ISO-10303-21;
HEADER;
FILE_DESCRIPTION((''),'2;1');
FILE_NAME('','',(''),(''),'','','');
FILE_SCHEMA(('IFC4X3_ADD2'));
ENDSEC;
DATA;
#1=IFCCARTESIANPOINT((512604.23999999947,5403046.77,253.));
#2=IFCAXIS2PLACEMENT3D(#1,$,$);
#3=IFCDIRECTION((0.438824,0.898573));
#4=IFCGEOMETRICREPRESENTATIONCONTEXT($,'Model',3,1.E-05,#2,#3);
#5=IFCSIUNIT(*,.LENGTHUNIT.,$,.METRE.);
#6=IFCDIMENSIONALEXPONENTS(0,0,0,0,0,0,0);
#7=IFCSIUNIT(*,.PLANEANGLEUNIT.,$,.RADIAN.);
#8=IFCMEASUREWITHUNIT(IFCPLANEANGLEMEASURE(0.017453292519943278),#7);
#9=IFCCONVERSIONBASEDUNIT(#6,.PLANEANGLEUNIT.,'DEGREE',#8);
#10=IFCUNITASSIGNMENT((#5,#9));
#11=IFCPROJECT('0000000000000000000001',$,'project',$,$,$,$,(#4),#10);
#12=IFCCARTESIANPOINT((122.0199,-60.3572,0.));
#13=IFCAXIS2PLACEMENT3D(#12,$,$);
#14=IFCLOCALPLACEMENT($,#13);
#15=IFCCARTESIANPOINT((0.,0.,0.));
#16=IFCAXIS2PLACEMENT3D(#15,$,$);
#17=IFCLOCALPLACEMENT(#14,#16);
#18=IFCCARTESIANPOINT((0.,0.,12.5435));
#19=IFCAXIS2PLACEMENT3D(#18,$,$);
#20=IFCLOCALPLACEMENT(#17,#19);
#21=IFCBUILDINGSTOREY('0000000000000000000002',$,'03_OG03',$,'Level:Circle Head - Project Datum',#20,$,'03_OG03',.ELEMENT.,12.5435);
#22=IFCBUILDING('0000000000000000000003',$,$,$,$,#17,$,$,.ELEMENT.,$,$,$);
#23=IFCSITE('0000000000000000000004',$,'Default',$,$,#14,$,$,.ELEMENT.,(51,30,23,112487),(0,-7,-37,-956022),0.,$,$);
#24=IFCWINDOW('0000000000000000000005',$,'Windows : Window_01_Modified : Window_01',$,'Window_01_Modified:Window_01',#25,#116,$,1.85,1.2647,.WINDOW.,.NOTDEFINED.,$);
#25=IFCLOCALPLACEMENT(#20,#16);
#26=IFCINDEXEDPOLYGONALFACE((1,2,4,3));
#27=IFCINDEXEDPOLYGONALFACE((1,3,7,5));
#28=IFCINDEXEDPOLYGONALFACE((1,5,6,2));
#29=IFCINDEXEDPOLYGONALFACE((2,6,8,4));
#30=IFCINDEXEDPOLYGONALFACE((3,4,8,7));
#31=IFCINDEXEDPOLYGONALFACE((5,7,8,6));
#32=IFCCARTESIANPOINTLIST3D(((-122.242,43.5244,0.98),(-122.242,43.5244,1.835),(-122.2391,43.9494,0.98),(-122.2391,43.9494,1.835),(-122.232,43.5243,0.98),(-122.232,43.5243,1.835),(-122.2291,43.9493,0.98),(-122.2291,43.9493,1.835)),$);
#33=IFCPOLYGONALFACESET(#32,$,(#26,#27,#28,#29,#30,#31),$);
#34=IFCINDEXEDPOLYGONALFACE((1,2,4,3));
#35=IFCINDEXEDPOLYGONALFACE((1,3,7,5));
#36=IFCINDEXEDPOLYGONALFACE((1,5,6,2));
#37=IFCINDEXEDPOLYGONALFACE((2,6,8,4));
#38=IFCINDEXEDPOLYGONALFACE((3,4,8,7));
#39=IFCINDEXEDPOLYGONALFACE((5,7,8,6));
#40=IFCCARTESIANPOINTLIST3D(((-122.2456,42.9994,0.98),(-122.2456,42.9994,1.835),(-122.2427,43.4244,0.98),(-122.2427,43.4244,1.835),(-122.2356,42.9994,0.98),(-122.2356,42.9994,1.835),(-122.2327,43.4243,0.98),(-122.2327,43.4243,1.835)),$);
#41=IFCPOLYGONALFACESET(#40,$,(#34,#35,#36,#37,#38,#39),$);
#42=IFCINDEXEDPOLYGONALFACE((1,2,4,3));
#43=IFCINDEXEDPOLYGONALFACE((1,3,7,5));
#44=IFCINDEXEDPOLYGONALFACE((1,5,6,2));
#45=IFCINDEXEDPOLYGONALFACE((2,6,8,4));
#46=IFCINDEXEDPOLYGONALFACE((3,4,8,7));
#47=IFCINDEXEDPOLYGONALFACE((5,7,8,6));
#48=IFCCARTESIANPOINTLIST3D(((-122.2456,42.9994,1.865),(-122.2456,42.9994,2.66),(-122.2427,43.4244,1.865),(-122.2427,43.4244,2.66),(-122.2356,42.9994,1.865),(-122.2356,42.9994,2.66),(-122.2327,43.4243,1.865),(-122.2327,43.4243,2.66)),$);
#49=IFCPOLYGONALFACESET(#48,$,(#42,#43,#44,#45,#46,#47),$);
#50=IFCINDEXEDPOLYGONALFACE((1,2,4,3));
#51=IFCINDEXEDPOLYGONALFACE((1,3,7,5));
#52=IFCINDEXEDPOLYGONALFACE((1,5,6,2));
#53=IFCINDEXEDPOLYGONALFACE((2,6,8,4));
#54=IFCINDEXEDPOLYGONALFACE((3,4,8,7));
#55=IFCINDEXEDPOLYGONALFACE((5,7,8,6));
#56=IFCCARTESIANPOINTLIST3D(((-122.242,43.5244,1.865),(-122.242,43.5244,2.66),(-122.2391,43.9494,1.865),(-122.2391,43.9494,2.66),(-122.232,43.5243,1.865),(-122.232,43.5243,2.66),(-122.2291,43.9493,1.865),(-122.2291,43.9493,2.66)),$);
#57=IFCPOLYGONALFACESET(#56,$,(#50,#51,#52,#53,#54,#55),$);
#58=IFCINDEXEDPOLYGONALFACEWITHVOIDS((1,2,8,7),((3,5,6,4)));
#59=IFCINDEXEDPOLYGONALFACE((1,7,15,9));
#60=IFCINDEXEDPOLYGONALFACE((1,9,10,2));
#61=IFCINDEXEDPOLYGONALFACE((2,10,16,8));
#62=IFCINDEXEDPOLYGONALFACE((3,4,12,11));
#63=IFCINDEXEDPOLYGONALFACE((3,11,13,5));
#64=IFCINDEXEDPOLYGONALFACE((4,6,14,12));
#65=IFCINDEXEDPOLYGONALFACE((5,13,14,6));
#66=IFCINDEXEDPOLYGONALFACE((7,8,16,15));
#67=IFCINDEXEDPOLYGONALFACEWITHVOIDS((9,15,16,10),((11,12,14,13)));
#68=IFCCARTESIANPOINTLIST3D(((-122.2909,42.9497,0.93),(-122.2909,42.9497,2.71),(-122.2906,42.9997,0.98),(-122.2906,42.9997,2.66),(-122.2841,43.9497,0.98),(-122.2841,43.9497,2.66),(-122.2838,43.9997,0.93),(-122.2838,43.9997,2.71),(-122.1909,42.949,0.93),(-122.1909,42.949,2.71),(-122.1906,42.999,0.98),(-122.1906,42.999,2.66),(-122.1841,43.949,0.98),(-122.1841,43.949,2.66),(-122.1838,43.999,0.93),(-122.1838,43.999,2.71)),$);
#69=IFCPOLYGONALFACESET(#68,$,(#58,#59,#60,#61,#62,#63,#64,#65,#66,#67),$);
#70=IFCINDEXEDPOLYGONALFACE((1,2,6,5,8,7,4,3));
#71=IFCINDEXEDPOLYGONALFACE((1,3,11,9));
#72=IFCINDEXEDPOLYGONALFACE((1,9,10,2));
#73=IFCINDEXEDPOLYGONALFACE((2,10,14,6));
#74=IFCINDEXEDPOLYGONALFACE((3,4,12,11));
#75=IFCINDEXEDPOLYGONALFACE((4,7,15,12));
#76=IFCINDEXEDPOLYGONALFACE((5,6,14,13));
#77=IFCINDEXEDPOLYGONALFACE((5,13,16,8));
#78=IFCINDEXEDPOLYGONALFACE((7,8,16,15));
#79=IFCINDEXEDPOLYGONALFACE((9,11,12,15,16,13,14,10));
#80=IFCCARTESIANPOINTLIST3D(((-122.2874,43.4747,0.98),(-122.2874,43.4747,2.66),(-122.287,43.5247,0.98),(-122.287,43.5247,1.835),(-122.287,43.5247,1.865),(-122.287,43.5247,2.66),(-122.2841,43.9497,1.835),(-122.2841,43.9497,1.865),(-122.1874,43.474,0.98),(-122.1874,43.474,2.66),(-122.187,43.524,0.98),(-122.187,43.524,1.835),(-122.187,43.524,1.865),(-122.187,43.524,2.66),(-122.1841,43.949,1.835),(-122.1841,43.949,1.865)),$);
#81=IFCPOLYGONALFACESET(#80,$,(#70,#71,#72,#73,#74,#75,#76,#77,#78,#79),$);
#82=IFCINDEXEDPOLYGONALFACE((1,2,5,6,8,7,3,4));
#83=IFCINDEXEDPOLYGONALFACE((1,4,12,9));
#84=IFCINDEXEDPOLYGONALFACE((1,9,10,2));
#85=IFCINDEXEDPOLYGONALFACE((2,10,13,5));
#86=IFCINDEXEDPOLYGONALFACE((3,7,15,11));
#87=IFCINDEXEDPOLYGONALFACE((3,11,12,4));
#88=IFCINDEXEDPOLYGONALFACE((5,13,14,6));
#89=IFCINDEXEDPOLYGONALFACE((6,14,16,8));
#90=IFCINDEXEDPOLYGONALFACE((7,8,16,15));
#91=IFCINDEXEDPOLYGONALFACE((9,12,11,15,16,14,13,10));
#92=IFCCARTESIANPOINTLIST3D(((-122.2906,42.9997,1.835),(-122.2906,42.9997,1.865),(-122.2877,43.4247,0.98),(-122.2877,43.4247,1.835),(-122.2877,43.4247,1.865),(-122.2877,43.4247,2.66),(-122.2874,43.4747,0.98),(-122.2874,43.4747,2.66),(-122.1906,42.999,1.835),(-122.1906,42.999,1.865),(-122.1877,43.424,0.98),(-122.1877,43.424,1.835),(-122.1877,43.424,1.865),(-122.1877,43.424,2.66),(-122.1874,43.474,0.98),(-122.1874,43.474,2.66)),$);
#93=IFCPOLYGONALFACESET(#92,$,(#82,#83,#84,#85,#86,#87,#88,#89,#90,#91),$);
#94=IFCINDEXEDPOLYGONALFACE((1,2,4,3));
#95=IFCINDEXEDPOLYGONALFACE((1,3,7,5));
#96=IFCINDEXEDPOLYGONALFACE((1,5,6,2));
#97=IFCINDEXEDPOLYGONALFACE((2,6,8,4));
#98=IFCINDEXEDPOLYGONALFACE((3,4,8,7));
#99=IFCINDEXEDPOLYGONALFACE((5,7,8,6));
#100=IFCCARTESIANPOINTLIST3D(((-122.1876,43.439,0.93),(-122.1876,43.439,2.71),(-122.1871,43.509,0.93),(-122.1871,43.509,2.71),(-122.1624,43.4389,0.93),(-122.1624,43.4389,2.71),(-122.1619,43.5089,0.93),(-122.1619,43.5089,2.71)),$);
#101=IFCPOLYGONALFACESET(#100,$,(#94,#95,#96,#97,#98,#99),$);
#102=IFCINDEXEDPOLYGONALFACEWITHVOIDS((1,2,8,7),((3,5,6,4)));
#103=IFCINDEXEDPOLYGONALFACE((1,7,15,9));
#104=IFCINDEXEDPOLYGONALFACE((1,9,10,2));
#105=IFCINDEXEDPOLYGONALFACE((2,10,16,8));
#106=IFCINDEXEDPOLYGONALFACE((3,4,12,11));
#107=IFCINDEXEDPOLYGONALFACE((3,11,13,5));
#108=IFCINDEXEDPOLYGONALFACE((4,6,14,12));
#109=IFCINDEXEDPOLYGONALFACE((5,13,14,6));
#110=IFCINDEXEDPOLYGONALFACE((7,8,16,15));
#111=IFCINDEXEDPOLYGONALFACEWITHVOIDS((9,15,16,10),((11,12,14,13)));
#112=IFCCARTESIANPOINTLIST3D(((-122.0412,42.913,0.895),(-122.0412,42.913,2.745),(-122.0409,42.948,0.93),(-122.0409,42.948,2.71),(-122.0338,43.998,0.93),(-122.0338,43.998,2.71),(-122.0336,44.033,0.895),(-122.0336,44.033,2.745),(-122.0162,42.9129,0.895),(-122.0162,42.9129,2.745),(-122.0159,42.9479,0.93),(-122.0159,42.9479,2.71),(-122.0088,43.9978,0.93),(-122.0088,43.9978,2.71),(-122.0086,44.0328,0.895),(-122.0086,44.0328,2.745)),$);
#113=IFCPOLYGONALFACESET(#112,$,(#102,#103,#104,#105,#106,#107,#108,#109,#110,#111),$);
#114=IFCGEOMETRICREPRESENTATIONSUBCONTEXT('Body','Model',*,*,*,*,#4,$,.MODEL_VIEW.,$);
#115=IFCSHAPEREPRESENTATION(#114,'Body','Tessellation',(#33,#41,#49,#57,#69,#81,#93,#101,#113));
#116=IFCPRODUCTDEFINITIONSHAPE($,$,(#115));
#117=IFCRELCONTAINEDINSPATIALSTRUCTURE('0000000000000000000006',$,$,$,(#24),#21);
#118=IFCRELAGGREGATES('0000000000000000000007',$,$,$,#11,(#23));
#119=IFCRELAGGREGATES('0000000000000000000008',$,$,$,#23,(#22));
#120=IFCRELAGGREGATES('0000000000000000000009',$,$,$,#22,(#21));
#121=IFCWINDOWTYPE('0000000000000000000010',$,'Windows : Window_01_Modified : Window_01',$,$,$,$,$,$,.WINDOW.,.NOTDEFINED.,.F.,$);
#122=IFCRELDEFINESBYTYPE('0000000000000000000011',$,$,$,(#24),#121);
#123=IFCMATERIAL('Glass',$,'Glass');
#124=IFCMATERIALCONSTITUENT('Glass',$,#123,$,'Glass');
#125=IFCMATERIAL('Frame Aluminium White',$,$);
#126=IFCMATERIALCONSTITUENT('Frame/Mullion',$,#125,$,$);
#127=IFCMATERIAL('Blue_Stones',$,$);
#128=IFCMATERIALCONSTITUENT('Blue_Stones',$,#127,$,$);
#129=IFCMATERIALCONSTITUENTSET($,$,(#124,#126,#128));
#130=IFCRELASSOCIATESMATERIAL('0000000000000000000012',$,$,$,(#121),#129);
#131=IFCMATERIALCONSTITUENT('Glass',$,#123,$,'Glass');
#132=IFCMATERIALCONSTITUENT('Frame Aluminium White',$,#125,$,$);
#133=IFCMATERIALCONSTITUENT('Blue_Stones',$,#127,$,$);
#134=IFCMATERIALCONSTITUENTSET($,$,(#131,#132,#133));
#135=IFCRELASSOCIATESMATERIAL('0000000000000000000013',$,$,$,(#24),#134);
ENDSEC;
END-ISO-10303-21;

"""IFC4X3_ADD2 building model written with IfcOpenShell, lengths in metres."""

from ifc_helpers import new_model, entity, si_unit, converted_unit, direction, frame, frame_2d, origin, place, context, subcontext, project, spatial, polyline, rectangle, outline, extrude, source, transform, mapped, material, constituent, constituent_set, type_object, type_shapes, element, save


model = new_model("IFC4X3_ADD2")

# Units and contexts
model_context = context("Model", 3, precision=1e-05, world=frame((512604.23999999947, 5403046.77, 253.0)), true_north=direction((0.438824, 0.898573)))
body_context = subcontext(model_context, "Body", "Model", "MODEL_VIEW")
ifc_project = project(units=[si_unit("LENGTHUNIT", "METRE"), converted_unit("PLANEANGLEUNIT", "DEGREE", entity("IfcPlaneAngleMeasure", 0.017453292519943278), si_unit("PLANEANGLEUNIT", "RADIAN"), dimensions=[0, 0, 0, 0, 0, 0, 0])], contexts=[model_context])

# Site, building, storey
site_placement = place(None, frame((122.0199, -60.3572, 0.0)))
site = spatial("IfcSite", under=ifc_project, at=site_placement, Name="Default", CompositionType="ELEMENT", RefLatitude=(51, 30, 23, 112487), RefLongitude=(0, -7, -37, -956022), RefElevation=0.0)
building_placement = place(site_placement, origin())
building = spatial("IfcBuilding", under=site, at=building_placement, CompositionType="ELEMENT")
storey_placement = place(building_placement, frame((0.0, 0.0, 12.5435)))
storey = spatial("IfcBuildingStorey", under=building, at=storey_placement, Name="03_OG03", ObjectType="Level:Circle Head - Project Datum", LongName="03_OG03", CompositionType="ELEMENT", Elevation=12.5435)

# Window
ifc_material_1 = material(Name="Glass", Category="Glass")
ifc_material_2 = material(Name="Frame Aluminium White")
ifc_material_3 = material(Name="Blue_Stones")
ifc_constituent_1 = constituent(ifc_material_1, Name="Glass", Category="Glass")
ifc_constituent_2 = constituent(ifc_material_2, Name="Frame Aluminium White")
ifc_constituent_3 = constituent(ifc_material_3, Name="Blue_Stones")
ifc_constituent_set_1 = constituent_set(constituents=[ifc_constituent_1, ifc_constituent_2, ifc_constituent_3])
ifc_constituent_4 = constituent(ifc_material_1, Name="Glass", Category="Glass")
ifc_constituent_5 = constituent(ifc_material_2, Name="Frame/Mullion")
ifc_constituent_6 = constituent(ifc_material_3, Name="Blue_Stones")
ifc_constituent_set_2 = constituent_set(constituents=[ifc_constituent_4, ifc_constituent_5, ifc_constituent_6])
window_type_1 = type_object("IfcWindowType", Name="Windows : Window_01_Modified : Window_01", ParameterTakesPrecedence=False, PartitioningType="NOTDEFINED", PredefinedType="WINDOW", material=ifc_constituent_set_2)
shared_shape_1 = source(origin(), body_context, "Body", "SweptSolid", [
    extrude(rectangle(XDim=0.425, YDim=0.01, at=frame_2d((0.0, 0.0), x_axis=(1.0, 0.0))), frame((0.4067, -0.2, 0.0514), z_axis=(0.0, 0.0, 1.0), x_axis=(-1.0, 0.0, 0.0)), (0.0, 0.0, 1.0), 0.855),
    extrude(rectangle(XDim=0.01, YDim=0.425, at=frame_2d((0.0, 0.0), x_axis=(1.0, 0.0))), frame((0.9317, -0.2, 0.0514), z_axis=(0.0, 0.0, 1.0), x_axis=(0.0, 1.0, 0.0)), (0.0, 0.0, 1.0), 0.855),
    extrude(rectangle(XDim=0.425, YDim=0.01, at=frame_2d((0.0, 0.0), x_axis=(1.0, 0.0))), frame((0.9317, -0.2, 0.9364), z_axis=(0.0, 0.0, 1.0), x_axis=(-1.0, 0.0, 0.0)), (0.0, 0.0, 1.0), 0.795),
    extrude(rectangle(XDim=0.425, YDim=0.01, at=frame_2d((0.0, 0.0), x_axis=(1.0, 0.0))), frame((0.4067, -0.2, 0.9364), z_axis=(0.0, 0.0, 1.0), x_axis=(-1.0, 0.0, 0.0)), (0.0, 0.0, 1.0), 0.795),
    extrude(outline(polyline([(-0.89, -0.525), (0.89, -0.525), (0.89, 0.525), (-0.89, 0.525), (-0.89, -0.525)]), holes=[polyline([(0.84, 0.475), (0.84, -0.475), (-0.84, -0.475), (-0.84, 0.475), (0.84, 0.475)])]), frame((0.6692, -0.25, 0.8914), z_axis=(0.0, 1.0, 0.0), x_axis=(0.0, 0.0, 1.0)), (0.0, 0.0, 1.0), 0.1),
    extrude(outline(polyline([(0.03, 0.0937), (0.825, 0.0937), (0.825, 0.1438), (-0.855, 0.1438), (-0.855, 0.0937), (0.0, 0.0937), (0.0, -0.3312), (0.03, -0.3312), (0.03, 0.0937)])), frame((0.5255, -0.25, 0.9064), z_axis=(0.0, 1.0, 0.0), x_axis=(0.0, 0.0, 1.0)), (0.0, 0.0, 1.0), 0.1),
    extrude(outline(polyline([(-0.825, -0.0938), (-0.825, -0.1437), (0.855, -0.1437), (0.855, -0.0938), (0.0, -0.0938), (0.0, 0.3313), (-0.03, 0.3313), (-0.03, -0.0938), (-0.825, -0.0938)])), frame((0.813, -0.25, 0.9064), z_axis=(0.0, -1.0, 0.0), x_axis=(0.0, 0.0, -1.0)), (0.0, 0.0, -1.0), 0.1),
    extrude(rectangle(XDim=0.0253, YDim=0.07, at=frame_2d((0.0, 0.0), x_axis=(1.0, 0.0))), frame((0.6692, -0.1374, 0.0014), z_axis=(0.0, 0.0, 1.0), x_axis=(0.0, -1.0, 0.0)), (0.0, 0.0, 1.0), 1.78),
    extrude(outline(polyline([(-0.56, -0.925), (0.56, -0.925), (0.56, 0.925), (-0.56, 0.925), (-0.56, -0.925)]), holes=[polyline([(-0.525, -0.89), (-0.525, 0.89), (0.525, 0.89), (0.525, -0.89), (-0.525, -0.89)])]), frame((0.6692, 0.0, 0.8914), z_axis=(0.0, 1.0, 0.0), x_axis=(1.0, 0.0, 0.0)), (0.0, 0.0, 1.0), 0.025),
])
type_shapes(window_type_1, [shared_shape_1])
window_1_placement = place(storey_placement, frame((-122.0328, 44.1423, 0.9286), z_axis=(0.0, 0.0, 1.0), x_axis=(-0.0068, -0.999977, 0.0)))
element("IfcWindow", 1, at=window_1_placement, inside=storey, type_object=window_type_1, material=ifc_constituent_set_1, Name="Windows : Window_01_Modified : Window_01", ObjectType="Window_01_Modified:Window_01", OverallHeight=1.85, OverallWidth=1.2647, PartitioningType="NOTDEFINED", PredefinedType="WINDOW", context=body_context, shape_type="MappedRepresentation", body=[
    mapped(shared_shape_1, transform((0.0, 0.0, 0.0), scale=1.0)),
])

save(model, "model.ifc")
